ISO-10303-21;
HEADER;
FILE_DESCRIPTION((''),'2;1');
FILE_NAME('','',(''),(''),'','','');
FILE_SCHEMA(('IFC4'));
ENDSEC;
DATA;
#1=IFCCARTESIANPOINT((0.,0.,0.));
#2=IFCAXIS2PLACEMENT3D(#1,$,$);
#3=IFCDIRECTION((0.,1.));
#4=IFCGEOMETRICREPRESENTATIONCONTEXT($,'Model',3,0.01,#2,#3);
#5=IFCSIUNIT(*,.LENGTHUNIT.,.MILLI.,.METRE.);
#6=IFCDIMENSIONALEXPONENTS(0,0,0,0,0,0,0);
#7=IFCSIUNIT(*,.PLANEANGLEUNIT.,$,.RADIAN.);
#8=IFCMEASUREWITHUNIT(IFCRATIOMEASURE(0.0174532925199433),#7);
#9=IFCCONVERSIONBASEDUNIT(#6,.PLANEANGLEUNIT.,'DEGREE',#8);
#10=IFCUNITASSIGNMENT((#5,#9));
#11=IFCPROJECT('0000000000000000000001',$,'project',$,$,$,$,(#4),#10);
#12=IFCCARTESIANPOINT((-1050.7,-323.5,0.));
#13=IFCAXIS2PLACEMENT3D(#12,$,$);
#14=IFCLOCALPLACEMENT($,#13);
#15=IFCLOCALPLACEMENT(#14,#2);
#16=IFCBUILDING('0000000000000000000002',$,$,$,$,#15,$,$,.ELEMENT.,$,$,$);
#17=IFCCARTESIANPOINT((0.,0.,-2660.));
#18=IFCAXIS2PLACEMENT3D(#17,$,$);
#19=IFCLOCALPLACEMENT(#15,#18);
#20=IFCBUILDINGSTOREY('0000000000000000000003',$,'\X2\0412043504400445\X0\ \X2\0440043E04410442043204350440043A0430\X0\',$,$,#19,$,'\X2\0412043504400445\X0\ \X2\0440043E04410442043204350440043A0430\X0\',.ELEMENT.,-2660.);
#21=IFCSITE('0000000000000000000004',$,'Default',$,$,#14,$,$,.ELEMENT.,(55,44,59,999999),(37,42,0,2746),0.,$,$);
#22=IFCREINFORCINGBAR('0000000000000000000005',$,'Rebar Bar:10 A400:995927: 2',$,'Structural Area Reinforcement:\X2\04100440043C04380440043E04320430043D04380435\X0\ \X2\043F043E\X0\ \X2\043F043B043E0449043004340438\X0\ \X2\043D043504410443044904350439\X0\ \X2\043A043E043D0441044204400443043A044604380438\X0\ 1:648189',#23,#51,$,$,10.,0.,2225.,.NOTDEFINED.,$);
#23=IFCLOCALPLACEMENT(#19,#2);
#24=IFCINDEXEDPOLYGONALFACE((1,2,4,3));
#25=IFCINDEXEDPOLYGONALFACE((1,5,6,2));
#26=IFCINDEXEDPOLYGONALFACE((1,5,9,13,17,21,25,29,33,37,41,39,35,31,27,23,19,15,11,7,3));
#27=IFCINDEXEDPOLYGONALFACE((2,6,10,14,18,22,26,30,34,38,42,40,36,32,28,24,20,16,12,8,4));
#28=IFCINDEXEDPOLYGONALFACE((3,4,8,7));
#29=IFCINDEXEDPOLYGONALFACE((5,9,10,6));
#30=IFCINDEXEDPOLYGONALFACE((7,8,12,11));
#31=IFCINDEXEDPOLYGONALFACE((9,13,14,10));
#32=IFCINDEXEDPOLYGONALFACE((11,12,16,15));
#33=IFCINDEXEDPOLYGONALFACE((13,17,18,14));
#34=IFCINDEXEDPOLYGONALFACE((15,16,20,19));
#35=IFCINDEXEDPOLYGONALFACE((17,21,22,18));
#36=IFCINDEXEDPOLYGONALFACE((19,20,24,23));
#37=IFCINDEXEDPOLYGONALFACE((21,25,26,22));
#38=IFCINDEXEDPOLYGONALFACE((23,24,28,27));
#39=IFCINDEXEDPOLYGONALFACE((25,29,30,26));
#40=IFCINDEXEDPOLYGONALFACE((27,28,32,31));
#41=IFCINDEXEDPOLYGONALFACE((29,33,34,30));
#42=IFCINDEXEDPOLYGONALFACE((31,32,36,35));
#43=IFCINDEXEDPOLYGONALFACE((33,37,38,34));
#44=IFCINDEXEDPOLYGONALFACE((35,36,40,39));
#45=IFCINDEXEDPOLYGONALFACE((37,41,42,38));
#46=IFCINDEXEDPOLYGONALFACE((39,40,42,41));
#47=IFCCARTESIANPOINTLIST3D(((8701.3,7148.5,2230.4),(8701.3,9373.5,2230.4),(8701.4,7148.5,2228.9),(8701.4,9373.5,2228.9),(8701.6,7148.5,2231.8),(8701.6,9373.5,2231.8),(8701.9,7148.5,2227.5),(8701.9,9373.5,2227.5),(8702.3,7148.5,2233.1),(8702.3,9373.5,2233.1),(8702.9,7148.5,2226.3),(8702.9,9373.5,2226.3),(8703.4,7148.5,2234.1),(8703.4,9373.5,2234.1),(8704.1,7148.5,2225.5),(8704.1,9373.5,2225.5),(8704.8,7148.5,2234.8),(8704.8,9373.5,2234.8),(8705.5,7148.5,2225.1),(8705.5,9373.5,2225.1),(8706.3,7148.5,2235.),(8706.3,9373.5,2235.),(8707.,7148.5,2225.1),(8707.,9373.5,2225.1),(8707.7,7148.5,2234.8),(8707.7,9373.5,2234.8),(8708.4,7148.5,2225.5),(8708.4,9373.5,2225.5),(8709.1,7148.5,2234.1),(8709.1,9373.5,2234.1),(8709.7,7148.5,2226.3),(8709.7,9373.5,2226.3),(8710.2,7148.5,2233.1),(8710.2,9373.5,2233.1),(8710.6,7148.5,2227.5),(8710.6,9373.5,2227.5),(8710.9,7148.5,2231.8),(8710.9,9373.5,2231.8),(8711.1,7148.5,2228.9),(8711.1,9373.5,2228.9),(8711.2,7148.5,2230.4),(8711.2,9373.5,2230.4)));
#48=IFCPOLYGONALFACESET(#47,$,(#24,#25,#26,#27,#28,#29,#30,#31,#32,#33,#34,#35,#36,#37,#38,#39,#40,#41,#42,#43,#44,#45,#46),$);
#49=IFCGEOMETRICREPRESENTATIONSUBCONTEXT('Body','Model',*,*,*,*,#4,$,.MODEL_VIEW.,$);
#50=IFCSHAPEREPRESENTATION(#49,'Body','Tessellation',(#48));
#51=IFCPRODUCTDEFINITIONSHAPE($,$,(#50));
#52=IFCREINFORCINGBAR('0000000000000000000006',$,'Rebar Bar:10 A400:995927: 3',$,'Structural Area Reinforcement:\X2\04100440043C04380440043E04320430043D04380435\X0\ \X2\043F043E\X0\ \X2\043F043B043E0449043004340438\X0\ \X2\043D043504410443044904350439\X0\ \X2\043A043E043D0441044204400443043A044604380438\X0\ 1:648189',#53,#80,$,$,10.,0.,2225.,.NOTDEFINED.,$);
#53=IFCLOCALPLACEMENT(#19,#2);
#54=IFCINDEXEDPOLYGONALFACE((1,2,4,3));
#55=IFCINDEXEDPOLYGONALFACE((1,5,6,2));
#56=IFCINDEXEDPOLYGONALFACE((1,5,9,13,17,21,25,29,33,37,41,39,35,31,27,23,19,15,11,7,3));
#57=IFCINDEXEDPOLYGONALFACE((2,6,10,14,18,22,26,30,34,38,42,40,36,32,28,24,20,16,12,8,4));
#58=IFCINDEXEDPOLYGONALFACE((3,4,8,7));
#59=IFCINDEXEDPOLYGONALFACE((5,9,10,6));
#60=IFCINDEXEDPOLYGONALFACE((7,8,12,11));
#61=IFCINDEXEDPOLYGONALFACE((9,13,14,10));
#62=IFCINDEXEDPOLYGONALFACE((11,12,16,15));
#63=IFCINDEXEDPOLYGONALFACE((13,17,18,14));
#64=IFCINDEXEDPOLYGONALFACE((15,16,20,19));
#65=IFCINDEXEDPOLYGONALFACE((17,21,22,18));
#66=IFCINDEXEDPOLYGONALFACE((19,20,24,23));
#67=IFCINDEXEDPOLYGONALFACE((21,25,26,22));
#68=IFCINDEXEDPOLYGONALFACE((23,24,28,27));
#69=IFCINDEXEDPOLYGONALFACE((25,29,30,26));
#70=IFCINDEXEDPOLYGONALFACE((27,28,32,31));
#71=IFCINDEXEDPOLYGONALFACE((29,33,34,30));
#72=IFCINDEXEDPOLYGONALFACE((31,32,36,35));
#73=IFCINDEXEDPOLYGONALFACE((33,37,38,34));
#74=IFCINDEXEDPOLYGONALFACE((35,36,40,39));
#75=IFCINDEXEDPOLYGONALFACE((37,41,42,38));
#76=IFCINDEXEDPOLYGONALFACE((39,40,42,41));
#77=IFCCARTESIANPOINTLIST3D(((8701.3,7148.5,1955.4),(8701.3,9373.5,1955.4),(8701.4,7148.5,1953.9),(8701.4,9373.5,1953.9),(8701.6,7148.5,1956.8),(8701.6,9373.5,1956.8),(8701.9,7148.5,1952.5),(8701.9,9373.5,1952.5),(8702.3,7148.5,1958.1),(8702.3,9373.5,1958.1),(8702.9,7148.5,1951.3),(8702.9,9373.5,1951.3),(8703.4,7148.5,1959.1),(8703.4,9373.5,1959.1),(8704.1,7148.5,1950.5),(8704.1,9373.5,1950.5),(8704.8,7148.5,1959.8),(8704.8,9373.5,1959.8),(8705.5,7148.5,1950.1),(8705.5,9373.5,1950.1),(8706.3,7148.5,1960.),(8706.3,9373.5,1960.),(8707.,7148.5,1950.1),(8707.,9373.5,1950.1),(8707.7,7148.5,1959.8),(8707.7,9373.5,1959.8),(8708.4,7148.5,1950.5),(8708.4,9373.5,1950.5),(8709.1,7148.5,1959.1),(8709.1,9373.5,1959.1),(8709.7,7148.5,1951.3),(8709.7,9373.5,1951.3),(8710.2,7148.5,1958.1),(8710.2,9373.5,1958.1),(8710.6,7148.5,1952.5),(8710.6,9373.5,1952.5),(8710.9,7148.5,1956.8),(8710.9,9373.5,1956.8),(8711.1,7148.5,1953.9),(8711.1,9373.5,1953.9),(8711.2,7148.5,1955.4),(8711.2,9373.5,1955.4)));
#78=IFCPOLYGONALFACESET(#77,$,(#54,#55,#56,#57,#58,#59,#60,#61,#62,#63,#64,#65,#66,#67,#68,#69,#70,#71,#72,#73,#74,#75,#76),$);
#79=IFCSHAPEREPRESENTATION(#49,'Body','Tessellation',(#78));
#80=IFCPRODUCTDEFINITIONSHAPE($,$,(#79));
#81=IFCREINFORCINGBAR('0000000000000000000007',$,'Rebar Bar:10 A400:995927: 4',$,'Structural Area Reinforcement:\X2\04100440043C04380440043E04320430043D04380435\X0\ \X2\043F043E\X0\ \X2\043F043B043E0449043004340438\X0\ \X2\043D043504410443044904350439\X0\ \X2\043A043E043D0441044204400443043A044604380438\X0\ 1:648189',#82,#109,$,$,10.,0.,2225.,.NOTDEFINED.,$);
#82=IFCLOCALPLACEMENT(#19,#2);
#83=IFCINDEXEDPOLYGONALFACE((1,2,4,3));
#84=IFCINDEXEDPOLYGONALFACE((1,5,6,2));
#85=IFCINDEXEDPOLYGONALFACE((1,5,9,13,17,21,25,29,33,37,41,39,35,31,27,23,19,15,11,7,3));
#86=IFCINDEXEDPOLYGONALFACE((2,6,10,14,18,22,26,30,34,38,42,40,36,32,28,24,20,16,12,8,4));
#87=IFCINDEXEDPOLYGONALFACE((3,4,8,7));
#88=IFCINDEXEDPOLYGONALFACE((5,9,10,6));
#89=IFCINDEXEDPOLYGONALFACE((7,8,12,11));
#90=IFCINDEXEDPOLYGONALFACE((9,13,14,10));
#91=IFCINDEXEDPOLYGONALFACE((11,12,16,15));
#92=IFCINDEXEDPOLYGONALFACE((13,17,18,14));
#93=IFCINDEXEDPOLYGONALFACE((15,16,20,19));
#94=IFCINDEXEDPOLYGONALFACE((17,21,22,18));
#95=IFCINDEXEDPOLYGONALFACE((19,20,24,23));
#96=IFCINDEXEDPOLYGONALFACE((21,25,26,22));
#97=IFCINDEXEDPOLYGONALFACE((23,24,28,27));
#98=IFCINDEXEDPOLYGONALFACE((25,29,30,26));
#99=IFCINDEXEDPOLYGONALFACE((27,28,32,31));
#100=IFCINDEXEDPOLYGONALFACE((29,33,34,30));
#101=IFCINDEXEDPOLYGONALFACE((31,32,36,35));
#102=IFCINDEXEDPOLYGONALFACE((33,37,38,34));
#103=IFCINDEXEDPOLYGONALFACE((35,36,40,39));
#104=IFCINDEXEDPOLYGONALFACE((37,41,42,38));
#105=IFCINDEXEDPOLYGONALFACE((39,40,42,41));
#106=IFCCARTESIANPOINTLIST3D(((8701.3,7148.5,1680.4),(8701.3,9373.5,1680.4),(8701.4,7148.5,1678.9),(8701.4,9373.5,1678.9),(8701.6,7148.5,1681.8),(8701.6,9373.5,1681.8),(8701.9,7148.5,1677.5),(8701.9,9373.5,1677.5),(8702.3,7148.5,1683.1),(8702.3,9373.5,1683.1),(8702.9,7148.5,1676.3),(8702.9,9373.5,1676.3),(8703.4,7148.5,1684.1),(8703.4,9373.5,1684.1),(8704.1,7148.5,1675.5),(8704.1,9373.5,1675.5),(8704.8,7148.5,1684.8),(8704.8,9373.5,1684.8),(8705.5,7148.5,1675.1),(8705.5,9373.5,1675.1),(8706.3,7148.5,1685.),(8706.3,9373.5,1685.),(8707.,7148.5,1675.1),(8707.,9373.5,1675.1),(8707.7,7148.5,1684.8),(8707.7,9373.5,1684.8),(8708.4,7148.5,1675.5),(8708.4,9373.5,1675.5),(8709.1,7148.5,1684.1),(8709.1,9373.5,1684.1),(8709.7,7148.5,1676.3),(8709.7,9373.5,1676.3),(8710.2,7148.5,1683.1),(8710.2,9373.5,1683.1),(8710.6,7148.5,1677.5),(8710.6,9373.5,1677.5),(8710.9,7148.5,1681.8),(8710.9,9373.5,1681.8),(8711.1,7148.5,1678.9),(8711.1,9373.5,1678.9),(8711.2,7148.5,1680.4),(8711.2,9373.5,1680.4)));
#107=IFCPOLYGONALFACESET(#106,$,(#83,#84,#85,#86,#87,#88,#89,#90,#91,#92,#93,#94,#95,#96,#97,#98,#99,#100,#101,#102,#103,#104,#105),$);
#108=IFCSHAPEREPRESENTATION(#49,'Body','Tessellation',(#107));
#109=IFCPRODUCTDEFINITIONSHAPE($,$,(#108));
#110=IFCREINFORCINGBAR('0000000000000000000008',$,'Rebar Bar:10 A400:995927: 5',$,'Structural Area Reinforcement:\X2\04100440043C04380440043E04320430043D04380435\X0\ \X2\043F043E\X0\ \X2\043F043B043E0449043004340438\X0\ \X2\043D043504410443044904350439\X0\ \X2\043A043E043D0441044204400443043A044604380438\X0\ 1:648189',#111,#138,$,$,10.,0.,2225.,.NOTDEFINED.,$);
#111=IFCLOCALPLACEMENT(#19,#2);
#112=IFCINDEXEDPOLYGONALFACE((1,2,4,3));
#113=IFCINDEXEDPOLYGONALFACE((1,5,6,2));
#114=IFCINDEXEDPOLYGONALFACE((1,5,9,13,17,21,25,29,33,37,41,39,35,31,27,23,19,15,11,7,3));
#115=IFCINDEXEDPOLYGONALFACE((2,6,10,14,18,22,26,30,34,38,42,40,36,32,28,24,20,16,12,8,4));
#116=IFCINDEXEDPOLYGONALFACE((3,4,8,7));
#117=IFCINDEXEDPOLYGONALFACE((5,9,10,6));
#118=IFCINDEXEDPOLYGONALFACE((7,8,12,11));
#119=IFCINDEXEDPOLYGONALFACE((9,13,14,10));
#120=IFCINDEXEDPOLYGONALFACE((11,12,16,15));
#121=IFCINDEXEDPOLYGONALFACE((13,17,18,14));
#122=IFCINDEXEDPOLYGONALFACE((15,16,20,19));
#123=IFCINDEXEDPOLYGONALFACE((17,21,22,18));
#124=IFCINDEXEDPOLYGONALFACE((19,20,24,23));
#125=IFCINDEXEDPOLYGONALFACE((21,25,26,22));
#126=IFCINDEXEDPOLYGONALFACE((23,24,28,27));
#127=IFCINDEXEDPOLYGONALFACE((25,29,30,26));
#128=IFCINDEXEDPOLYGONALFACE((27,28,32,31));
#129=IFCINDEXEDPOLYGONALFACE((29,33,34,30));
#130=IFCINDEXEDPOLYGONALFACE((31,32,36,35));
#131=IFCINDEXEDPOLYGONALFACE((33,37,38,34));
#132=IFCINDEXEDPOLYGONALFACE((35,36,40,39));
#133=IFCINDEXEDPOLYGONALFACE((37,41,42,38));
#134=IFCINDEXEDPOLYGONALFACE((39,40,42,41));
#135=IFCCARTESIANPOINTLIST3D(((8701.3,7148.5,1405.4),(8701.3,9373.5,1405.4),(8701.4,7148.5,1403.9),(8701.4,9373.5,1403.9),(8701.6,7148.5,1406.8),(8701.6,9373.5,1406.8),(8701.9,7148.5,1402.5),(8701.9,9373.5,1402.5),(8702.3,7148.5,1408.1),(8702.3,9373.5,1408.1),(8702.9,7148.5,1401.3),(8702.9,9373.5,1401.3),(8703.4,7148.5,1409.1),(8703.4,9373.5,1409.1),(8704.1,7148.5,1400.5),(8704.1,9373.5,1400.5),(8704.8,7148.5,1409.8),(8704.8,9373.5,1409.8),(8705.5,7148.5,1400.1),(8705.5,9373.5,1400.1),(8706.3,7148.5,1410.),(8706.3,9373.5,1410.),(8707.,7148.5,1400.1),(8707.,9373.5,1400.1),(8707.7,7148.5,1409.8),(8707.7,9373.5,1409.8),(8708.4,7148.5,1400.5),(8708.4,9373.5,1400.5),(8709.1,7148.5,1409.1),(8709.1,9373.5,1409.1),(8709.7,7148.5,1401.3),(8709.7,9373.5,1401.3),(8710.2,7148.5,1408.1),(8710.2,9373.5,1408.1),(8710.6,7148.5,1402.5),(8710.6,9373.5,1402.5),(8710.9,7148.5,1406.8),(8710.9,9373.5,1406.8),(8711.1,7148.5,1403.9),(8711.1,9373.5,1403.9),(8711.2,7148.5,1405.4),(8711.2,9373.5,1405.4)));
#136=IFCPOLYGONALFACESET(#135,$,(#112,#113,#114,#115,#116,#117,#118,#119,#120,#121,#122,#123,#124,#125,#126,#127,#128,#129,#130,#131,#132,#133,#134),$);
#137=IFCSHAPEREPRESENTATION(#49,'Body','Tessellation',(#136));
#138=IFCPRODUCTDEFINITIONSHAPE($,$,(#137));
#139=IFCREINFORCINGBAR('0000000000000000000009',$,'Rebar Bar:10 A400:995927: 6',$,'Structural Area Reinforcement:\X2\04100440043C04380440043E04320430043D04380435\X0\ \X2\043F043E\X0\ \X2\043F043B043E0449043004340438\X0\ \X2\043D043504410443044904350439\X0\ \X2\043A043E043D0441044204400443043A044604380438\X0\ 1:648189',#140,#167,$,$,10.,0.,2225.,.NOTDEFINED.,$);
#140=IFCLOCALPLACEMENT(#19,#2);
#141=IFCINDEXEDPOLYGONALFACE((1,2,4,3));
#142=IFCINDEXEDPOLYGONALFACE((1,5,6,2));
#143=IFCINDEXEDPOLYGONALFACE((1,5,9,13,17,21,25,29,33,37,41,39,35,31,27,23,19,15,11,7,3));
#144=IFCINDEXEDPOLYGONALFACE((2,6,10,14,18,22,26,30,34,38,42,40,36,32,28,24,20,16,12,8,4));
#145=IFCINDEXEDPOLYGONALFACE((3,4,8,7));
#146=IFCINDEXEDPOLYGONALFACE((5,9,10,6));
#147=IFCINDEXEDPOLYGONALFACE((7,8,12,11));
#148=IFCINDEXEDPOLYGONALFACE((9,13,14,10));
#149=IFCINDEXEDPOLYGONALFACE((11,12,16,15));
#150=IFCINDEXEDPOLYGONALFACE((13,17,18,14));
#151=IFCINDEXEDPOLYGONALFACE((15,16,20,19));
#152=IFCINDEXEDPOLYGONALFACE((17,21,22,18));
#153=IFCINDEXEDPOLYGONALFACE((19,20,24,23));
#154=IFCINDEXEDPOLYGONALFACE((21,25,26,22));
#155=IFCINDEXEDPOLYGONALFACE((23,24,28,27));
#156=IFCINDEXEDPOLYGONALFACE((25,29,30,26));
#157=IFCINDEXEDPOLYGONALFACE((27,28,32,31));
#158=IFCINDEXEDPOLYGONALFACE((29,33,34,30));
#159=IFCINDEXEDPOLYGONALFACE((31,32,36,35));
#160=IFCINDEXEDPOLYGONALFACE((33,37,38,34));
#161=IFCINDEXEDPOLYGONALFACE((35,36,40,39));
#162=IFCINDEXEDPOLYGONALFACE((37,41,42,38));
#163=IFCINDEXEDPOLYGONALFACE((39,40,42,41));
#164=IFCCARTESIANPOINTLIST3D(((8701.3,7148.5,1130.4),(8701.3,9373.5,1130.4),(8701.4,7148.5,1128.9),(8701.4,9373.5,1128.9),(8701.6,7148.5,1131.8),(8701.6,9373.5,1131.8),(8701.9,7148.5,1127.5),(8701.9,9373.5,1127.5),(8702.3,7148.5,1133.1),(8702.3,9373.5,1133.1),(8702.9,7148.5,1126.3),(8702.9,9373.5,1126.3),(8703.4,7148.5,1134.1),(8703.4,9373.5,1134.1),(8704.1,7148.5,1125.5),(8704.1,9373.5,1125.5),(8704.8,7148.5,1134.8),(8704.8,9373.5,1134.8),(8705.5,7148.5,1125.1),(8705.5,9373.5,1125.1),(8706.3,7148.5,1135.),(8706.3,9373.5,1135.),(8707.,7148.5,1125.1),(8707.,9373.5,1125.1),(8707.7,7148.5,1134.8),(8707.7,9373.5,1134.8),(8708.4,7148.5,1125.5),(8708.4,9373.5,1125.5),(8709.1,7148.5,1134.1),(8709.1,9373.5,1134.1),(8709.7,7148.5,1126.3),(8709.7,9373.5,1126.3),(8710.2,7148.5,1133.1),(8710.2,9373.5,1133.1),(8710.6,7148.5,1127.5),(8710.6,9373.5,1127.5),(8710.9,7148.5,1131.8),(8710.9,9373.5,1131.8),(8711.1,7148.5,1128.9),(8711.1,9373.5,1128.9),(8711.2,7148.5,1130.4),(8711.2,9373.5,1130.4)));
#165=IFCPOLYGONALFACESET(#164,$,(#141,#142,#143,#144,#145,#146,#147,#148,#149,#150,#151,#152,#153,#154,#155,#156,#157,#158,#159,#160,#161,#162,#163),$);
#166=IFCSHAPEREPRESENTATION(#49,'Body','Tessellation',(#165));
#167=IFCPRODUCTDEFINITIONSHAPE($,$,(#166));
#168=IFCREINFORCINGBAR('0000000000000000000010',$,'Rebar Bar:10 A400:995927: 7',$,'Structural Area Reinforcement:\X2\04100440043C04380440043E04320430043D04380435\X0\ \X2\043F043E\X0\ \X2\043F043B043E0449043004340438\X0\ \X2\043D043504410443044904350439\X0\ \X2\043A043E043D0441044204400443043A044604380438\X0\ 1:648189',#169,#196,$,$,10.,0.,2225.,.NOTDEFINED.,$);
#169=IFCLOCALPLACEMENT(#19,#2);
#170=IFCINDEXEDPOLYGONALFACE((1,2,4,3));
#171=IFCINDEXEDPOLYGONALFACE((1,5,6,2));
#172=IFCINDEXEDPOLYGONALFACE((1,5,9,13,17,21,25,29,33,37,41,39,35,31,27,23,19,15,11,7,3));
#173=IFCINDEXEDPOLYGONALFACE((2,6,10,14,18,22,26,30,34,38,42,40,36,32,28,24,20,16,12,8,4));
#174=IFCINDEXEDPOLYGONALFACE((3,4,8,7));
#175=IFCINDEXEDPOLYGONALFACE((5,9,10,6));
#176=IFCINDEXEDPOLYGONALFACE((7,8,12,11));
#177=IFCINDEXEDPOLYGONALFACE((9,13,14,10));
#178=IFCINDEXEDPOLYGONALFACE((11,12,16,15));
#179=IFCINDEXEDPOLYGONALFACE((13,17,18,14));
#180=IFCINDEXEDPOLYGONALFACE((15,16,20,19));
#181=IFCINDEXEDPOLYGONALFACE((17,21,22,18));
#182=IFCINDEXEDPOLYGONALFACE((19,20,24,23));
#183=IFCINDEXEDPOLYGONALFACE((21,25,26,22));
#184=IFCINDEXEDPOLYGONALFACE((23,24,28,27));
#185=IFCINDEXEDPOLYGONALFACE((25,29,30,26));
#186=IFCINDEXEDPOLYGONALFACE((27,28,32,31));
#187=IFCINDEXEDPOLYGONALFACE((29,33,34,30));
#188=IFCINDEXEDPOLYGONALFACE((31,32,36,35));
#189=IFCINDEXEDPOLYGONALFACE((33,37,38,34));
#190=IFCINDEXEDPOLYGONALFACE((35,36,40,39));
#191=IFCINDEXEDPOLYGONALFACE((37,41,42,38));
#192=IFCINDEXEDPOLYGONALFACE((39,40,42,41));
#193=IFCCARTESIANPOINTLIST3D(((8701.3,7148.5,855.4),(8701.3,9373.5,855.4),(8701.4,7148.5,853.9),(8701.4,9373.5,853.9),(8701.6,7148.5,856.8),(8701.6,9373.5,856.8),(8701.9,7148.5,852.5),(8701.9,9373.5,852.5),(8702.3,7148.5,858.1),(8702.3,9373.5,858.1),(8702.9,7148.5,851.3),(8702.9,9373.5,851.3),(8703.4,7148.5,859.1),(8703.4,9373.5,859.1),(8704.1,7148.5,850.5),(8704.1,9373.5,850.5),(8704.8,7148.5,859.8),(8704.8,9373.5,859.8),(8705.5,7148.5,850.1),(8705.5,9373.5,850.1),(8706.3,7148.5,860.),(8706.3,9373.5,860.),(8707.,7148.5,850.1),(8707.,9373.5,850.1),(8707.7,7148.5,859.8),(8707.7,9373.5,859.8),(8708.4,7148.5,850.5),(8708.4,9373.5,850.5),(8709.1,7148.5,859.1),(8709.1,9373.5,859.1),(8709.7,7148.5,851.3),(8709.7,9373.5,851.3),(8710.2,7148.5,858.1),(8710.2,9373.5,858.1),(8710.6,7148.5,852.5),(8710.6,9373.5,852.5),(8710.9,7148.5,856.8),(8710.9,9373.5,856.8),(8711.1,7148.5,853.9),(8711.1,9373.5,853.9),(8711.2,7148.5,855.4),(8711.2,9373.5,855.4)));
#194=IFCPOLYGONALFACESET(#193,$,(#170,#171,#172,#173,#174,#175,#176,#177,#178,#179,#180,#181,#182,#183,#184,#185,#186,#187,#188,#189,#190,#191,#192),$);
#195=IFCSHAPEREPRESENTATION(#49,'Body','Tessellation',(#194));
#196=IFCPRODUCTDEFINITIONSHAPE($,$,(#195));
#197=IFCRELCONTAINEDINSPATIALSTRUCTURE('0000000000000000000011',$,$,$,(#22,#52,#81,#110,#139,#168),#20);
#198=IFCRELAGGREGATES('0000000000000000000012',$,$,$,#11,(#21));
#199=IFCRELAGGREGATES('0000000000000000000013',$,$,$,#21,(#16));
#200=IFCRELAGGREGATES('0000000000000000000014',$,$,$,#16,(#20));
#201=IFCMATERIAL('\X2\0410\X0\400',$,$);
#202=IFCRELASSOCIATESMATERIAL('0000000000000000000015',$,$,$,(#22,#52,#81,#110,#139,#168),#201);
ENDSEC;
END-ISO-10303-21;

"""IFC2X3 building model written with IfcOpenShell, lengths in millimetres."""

from ifc_helpers import new_model, entity, si_unit, converted_unit, direction, frame, origin, place, context, subcontext, project, spatial, material, element, save


model = new_model("IFC2X3")

# Units and contexts
model_context = context("Model", 3, precision=0.01, world=origin(), true_north=direction((0.0, 1.0)))
body_context = subcontext(model_context, "Body", "Model", "MODEL_VIEW")
ifc_project = project(units=[si_unit("LENGTHUNIT", "METRE", prefix="MILLI"), converted_unit("PLANEANGLEUNIT", "DEGREE", entity("IfcRatioMeasure", 0.0174532925199433), si_unit("PLANEANGLEUNIT", "RADIAN"), dimensions=[0, 0, 0, 0, 0, 0, 0])], contexts=[model_context])

# Site, building, storey
site_placement = place(None, frame((-1050.7, -323.5, 0.0)))
site = spatial("IfcSite", under=ifc_project, at=site_placement, Name="Default", CompositionType="ELEMENT", RefLatitude=(55, 44, 59, 999999), RefLongitude=(37, 42, 0, 2746), RefElevation=0.0)
building_placement = place(site_placement, origin())
building = spatial("IfcBuilding", under=site, at=building_placement, CompositionType="ELEMENT")
storey_placement = place(building_placement, frame((0.0, 0.0, -2660.0)))
storey = spatial("IfcBuildingStorey", under=building, at=storey_placement, Name="Верх ростверка", LongName="Верх ростверка", CompositionType="ELEMENT", Elevation=-2660.0)

# Reinforcing bars
ifc_material = material(Name="А400")
reinforcing_bar_1_placement = place(storey_placement, origin())
element("IfcReinforcingBar", 1, at=reinforcing_bar_1_placement, inside=storey, material=ifc_material, Name="Rebar Bar:10 A400:995927: 2", ObjectType="Structural Area Reinforcement:Армирование по площади несущей конструкции 1:648189", BarLength=2225.0, BarRole="NOTDEFINED", CrossSectionArea=0.0, NominalDiameter=10.0, context=body_context, shape_type="AdvancedSweptSolid", body=[
    entity("IfcSweptDiskSolid", entity("IfcCompositeCurve", [entity("IfcCompositeCurveSegment", "CONTINUOUS", True, entity("IfcPolyline", [entity("IfcCartesianPoint", [8706.3, 7148.5, 2230.0]), entity("IfcCartesianPoint", [8706.3, 9373.5, 2230.0])]))], False), 5.0, None, 0.0, 1.0),
])
reinforcing_bar_2_placement = place(storey_placement, origin())
element("IfcReinforcingBar", 2, at=reinforcing_bar_2_placement, inside=storey, material=ifc_material, Name="Rebar Bar:10 A400:995927: 3", ObjectType="Structural Area Reinforcement:Армирование по площади несущей конструкции 1:648189", BarLength=2225.0, BarRole="NOTDEFINED", CrossSectionArea=0.0, NominalDiameter=10.0, context=body_context, shape_type="AdvancedSweptSolid", body=[
    entity("IfcSweptDiskSolid", entity("IfcCompositeCurve", [entity("IfcCompositeCurveSegment", "CONTINUOUS", True, entity("IfcPolyline", [entity("IfcCartesianPoint", [8706.3, 7148.5, 1955.0]), entity("IfcCartesianPoint", [8706.3, 9373.5, 1955.0])]))], False), 5.0, None, 0.0, 1.0),
])
reinforcing_bar_3_placement = place(storey_placement, origin())
element("IfcReinforcingBar", 3, at=reinforcing_bar_3_placement, inside=storey, material=ifc_material, Name="Rebar Bar:10 A400:995927: 4", ObjectType="Structural Area Reinforcement:Армирование по площади несущей конструкции 1:648189", BarLength=2225.0, BarRole="NOTDEFINED", CrossSectionArea=0.0, NominalDiameter=10.0, context=body_context, shape_type="AdvancedSweptSolid", body=[
    entity("IfcSweptDiskSolid", entity("IfcCompositeCurve", [entity("IfcCompositeCurveSegment", "CONTINUOUS", True, entity("IfcPolyline", [entity("IfcCartesianPoint", [8706.3, 7148.5, 1680.0]), entity("IfcCartesianPoint", [8706.3, 9373.5, 1680.0])]))], False), 5.0, None, 0.0, 1.0),
])
reinforcing_bar_4_placement = place(storey_placement, origin())
element("IfcReinforcingBar", 4, at=reinforcing_bar_4_placement, inside=storey, material=ifc_material, Name="Rebar Bar:10 A400:995927: 5", ObjectType="Structural Area Reinforcement:Армирование по площади несущей конструкции 1:648189", BarLength=2225.0, BarRole="NOTDEFINED", CrossSectionArea=0.0, NominalDiameter=10.0, context=body_context, shape_type="AdvancedSweptSolid", body=[
    entity("IfcSweptDiskSolid", entity("IfcCompositeCurve", [entity("IfcCompositeCurveSegment", "CONTINUOUS", True, entity("IfcPolyline", [entity("IfcCartesianPoint", [8706.3, 7148.5, 1405.0]), entity("IfcCartesianPoint", [8706.3, 9373.5, 1405.0])]))], False), 5.0, None, 0.0, 1.0),
])
reinforcing_bar_5_placement = place(storey_placement, origin())
element("IfcReinforcingBar", 5, at=reinforcing_bar_5_placement, inside=storey, material=ifc_material, Name="Rebar Bar:10 A400:995927: 6", ObjectType="Structural Area Reinforcement:Армирование по площади несущей конструкции 1:648189", BarLength=2225.0, BarRole="NOTDEFINED", CrossSectionArea=0.0, NominalDiameter=10.0, context=body_context, shape_type="AdvancedSweptSolid", body=[
    entity("IfcSweptDiskSolid", entity("IfcCompositeCurve", [entity("IfcCompositeCurveSegment", "CONTINUOUS", True, entity("IfcPolyline", [entity("IfcCartesianPoint", [8706.3, 7148.5, 1130.0]), entity("IfcCartesianPoint", [8706.3, 9373.5, 1130.0])]))], False), 5.0, None, 0.0, 1.0),
])
reinforcing_bar_6_placement = place(storey_placement, origin())
element("IfcReinforcingBar", 6, at=reinforcing_bar_6_placement, inside=storey, material=ifc_material, Name="Rebar Bar:10 A400:995927: 7", ObjectType="Structural Area Reinforcement:Армирование по площади несущей конструкции 1:648189", BarLength=2225.0, BarRole="NOTDEFINED", CrossSectionArea=0.0, NominalDiameter=10.0, context=body_context, shape_type="AdvancedSweptSolid", body=[
    entity("IfcSweptDiskSolid", entity("IfcCompositeCurve", [entity("IfcCompositeCurveSegment", "CONTINUOUS", True, entity("IfcPolyline", [entity("IfcCartesianPoint", [8706.3, 7148.5, 855.0]), entity("IfcCartesianPoint", [8706.3, 9373.5, 855.0])]))], False), 5.0, None, 0.0, 1.0),
])

save(model, "model.ifc")
